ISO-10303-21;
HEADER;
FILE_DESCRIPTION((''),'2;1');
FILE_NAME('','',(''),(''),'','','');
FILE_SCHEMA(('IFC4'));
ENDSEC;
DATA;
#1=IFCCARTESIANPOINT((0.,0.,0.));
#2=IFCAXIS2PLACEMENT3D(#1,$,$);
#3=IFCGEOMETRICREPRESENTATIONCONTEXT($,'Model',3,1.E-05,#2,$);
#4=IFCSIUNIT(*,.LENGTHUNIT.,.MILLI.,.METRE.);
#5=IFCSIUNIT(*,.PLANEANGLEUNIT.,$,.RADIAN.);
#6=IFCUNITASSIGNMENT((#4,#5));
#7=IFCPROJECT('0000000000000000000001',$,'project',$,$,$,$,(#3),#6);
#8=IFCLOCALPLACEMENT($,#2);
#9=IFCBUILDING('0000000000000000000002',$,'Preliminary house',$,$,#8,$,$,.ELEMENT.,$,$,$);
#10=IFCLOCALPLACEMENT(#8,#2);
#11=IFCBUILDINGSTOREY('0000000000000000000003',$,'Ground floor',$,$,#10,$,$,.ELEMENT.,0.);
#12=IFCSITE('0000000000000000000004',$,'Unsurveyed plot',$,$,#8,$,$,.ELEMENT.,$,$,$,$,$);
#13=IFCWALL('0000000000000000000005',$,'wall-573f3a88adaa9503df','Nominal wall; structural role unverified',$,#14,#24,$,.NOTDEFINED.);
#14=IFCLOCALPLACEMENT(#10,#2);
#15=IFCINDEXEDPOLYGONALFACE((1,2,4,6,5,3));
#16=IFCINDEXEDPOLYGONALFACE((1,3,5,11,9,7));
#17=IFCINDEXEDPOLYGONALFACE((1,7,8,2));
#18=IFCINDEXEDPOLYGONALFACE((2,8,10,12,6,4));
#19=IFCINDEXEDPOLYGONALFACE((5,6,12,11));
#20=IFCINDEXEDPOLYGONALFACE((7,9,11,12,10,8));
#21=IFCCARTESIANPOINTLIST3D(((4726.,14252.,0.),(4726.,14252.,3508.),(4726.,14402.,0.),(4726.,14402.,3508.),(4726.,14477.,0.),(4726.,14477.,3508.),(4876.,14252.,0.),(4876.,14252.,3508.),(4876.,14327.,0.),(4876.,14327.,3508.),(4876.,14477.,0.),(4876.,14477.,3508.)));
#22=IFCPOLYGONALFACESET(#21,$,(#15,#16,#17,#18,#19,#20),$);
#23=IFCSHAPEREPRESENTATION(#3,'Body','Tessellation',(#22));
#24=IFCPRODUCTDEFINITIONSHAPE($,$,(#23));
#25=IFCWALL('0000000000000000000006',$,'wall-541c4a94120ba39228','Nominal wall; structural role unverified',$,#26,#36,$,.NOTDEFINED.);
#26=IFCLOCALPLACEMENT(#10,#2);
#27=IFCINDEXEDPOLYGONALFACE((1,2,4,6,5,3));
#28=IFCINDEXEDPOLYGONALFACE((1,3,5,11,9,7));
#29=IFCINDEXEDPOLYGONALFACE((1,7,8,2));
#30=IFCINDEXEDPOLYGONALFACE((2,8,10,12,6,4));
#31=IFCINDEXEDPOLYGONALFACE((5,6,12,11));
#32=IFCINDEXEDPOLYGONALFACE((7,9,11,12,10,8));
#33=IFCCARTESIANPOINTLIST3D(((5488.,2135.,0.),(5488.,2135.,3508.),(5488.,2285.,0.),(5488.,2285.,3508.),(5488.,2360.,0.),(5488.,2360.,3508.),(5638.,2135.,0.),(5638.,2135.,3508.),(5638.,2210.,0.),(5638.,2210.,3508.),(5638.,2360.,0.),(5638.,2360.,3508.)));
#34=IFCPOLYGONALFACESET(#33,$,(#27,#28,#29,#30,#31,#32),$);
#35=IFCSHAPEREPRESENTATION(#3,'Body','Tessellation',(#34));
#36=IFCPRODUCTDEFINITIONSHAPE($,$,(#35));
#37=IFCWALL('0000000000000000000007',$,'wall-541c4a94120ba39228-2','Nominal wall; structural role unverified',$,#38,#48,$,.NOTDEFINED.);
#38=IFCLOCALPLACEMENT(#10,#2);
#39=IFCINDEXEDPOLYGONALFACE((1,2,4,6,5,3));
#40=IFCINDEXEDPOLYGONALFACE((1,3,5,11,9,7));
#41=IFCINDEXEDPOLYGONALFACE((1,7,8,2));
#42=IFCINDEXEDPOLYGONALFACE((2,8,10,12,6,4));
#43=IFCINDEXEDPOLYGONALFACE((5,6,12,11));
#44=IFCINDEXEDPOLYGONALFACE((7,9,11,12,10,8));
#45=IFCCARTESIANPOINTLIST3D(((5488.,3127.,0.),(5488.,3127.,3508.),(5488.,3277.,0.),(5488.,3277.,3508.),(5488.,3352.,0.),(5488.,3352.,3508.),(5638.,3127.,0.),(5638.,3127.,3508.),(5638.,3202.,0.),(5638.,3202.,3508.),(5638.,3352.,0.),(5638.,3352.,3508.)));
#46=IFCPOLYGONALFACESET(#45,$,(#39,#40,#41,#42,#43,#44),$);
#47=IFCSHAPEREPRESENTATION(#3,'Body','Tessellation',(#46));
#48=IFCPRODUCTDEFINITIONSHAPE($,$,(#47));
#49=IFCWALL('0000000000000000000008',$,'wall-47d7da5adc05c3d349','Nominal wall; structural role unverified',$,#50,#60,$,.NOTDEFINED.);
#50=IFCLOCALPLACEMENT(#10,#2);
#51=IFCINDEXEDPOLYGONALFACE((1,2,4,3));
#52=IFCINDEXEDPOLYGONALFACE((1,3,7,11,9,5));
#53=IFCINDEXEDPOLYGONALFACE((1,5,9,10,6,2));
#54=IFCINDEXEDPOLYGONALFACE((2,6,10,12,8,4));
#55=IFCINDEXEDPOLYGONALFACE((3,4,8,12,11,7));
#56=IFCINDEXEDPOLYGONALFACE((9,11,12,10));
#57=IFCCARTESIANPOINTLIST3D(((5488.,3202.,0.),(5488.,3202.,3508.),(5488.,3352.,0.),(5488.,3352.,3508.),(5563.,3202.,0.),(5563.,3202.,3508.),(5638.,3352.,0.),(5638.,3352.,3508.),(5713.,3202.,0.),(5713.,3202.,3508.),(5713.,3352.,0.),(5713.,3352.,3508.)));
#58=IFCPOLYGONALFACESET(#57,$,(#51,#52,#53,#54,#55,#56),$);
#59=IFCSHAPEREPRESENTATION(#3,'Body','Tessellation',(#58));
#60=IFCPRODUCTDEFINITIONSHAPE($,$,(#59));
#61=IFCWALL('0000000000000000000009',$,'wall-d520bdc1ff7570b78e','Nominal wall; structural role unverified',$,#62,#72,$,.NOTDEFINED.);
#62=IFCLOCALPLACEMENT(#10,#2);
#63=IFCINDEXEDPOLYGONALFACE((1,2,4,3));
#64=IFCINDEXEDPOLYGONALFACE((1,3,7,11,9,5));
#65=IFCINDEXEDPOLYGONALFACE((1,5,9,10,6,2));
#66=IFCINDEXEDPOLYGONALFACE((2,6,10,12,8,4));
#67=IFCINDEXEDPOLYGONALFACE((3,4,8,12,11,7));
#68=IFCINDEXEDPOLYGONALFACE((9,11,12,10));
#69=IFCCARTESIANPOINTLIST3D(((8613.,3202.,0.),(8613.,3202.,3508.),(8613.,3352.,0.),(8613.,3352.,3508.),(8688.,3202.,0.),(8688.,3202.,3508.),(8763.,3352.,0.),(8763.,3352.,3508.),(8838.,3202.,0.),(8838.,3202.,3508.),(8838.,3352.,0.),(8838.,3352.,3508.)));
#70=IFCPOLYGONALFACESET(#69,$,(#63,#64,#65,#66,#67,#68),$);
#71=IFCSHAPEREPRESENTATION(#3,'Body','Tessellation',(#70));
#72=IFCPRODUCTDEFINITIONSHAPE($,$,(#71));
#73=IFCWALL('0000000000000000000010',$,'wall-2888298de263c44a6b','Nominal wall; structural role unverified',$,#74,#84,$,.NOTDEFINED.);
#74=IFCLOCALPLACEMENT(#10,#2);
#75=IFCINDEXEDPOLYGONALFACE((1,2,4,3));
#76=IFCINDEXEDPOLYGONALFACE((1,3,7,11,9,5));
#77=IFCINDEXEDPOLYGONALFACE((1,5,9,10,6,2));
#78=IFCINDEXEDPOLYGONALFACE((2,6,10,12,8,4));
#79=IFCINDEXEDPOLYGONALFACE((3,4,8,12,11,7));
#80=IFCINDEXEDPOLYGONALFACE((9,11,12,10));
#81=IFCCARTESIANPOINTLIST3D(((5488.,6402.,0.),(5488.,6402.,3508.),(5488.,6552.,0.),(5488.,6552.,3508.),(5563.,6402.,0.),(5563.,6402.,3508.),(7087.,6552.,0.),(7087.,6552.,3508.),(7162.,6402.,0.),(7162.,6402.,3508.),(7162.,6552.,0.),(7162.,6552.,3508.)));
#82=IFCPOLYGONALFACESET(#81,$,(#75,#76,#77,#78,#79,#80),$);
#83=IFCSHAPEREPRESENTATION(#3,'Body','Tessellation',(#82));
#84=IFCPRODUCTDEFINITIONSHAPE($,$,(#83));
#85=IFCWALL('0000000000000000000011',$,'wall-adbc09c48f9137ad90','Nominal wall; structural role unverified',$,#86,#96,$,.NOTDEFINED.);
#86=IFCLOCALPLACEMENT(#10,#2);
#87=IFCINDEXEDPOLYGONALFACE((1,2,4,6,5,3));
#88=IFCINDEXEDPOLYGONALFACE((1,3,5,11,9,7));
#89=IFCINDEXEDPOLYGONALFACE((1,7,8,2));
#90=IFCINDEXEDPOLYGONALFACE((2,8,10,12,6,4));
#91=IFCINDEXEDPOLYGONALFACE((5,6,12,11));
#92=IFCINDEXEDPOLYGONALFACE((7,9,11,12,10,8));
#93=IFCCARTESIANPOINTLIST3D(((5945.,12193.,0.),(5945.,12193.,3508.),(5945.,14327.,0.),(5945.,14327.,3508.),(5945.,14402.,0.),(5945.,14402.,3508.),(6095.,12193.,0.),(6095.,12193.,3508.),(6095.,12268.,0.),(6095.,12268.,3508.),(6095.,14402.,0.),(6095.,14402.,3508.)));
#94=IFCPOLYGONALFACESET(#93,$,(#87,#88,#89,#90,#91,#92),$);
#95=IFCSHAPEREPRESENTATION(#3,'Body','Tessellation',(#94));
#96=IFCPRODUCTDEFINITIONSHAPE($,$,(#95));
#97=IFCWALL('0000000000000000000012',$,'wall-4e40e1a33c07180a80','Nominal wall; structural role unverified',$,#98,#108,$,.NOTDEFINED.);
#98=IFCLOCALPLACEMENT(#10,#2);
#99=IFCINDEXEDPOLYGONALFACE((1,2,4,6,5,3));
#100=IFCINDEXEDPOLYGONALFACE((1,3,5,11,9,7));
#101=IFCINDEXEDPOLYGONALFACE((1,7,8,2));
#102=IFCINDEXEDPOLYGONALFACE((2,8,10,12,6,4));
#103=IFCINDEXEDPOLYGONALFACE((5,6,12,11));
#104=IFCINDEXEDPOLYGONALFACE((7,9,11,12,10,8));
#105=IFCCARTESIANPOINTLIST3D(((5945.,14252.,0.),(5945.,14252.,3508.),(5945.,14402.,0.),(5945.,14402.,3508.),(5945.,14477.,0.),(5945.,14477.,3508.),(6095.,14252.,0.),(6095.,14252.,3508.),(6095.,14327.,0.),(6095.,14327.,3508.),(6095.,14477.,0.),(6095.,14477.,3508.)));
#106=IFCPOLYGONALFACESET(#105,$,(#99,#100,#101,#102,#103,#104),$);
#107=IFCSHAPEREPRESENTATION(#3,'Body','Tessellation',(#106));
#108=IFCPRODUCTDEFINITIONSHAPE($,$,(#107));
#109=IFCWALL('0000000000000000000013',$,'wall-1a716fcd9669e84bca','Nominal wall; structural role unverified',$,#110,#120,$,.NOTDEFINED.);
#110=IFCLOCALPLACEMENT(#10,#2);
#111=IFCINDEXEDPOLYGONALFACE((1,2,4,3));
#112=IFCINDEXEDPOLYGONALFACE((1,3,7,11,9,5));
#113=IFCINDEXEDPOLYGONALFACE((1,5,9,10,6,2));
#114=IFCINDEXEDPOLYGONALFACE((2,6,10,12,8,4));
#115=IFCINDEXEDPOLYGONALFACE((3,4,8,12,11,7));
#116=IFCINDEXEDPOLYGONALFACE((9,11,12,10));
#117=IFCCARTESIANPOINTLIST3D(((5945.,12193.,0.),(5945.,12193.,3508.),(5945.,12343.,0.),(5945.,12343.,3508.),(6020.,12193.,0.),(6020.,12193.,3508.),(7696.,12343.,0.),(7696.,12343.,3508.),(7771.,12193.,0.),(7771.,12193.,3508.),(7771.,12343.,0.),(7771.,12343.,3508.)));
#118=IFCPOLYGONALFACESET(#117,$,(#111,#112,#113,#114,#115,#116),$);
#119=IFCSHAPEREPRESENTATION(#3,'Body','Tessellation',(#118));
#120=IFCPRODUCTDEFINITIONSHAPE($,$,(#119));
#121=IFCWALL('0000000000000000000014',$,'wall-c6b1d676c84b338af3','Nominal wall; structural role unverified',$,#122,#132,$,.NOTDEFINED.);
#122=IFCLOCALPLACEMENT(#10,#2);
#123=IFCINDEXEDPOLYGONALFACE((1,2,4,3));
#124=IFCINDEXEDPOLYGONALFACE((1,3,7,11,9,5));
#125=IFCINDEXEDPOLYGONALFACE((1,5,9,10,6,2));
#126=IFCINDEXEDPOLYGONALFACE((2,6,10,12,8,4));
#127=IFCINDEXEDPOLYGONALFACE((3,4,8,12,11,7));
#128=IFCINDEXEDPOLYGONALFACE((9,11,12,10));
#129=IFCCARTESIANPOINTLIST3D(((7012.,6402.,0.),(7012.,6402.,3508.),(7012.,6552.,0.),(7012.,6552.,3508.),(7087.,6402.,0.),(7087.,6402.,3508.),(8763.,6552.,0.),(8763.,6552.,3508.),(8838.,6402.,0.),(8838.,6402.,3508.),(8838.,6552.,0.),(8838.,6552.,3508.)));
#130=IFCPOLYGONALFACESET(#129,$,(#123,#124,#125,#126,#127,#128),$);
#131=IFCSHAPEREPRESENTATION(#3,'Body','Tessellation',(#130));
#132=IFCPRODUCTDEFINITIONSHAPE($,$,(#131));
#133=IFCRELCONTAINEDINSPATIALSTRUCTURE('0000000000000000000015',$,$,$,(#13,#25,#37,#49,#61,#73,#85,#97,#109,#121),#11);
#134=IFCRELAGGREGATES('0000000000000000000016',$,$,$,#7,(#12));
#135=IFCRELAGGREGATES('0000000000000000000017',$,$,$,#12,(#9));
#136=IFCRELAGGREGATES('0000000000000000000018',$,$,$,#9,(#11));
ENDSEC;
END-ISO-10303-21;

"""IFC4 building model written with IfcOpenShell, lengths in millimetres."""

from ifc_helpers import new_model, si_unit, origin, place, context, project, spatial, polyline, outline, extrude, element, save


model = new_model("IFC4")

# Units and contexts
model_context = context("Model", 3, precision=1e-05, world=origin())
ifc_project = project(units=[si_unit("LENGTHUNIT", "METRE", prefix="MILLI"), si_unit("PLANEANGLEUNIT", "RADIAN")], contexts=[model_context])

# Site, building, storey
placement_1 = place(None, origin())
site = spatial("IfcSite", under=ifc_project, at=placement_1, Name="Unsurveyed plot", CompositionType="ELEMENT")
building = spatial("IfcBuilding", under=site, at=placement_1, Name="Preliminary house", CompositionType="ELEMENT")
placement_2 = place(placement_1, origin())
storey = spatial("IfcBuildingStorey", under=building, at=placement_2, Name="Ground floor", CompositionType="ELEMENT", Elevation=0.0)

# Walls
element("IfcWall", 1, at=placement_2, inside=storey, Name="wall-573f3a88adaa9503df", Description="Nominal wall; structural role unverified", PredefinedType="NOTDEFINED", context=model_context, shape_type="SweptSolid", body=[
    extrude(outline(polyline([(4726.0, 14402.0), (4726.0, 14477.0), (4876.0, 14477.0), (4876.0, 14327.0), (4876.0, 14252.0), (4726.0, 14252.0), (4726.0, 14402.0)])), origin(), (0.0, 0.0, 1.0), 3508.0),
])
element("IfcWall", 2, at=placement_2, inside=storey, Name="wall-541c4a94120ba39228", Description="Nominal wall; structural role unverified", PredefinedType="NOTDEFINED", context=model_context, shape_type="SweptSolid", body=[
    extrude(outline(polyline([(5488.0, 2285.0), (5488.0, 2360.0), (5638.0, 2360.0), (5638.0, 2210.0), (5638.0, 2135.0), (5488.0, 2135.0), (5488.0, 2285.0)])), origin(), (0.0, 0.0, 1.0), 3508.0),
])

# Wall
element("IfcWall", 3, at=placement_2, inside=storey, Name="wall-541c4a94120ba39228-2", Description="Nominal wall; structural role unverified", PredefinedType="NOTDEFINED", context=model_context, shape_type="SweptSolid", body=[
    extrude(outline(polyline([(5488.0, 3277.0), (5488.0, 3352.0), (5638.0, 3352.0), (5638.0, 3202.0), (5638.0, 3127.0), (5488.0, 3127.0), (5488.0, 3277.0)])), origin(), (0.0, 0.0, 1.0), 3508.0),
])

# Wall
element("IfcWall", 4, at=placement_2, inside=storey, Name="wall-47d7da5adc05c3d349", Description="Nominal wall; structural role unverified", PredefinedType="NOTDEFINED", context=model_context, shape_type="SweptSolid", body=[
    extrude(outline(polyline([(5638.0, 3352.0), (5713.0, 3352.0), (5713.0, 3202.0), (5563.0, 3202.0), (5488.0, 3202.0), (5488.0, 3352.0), (5638.0, 3352.0)])), origin(), (0.0, 0.0, 1.0), 3508.0),
])

# Walls
element("IfcWall", 5, at=placement_2, inside=storey, Name="wall-d520bdc1ff7570b78e", Description="Nominal wall; structural role unverified", PredefinedType="NOTDEFINED", context=model_context, shape_type="SweptSolid", body=[
    extrude(outline(polyline([(8763.0, 3352.0), (8838.0, 3352.0), (8838.0, 3202.0), (8688.0, 3202.0), (8613.0, 3202.0), (8613.0, 3352.0), (8763.0, 3352.0)])), origin(), (0.0, 0.0, 1.0), 3508.0),
])
element("IfcWall", 6, at=placement_2, inside=storey, Name="wall-2888298de263c44a6b", Description="Nominal wall; structural role unverified", PredefinedType="NOTDEFINED", context=model_context, shape_type="SweptSolid", body=[
    extrude(outline(polyline([(7087.0, 6552.0), (7162.0, 6552.0), (7162.0, 6402.0), (5563.0, 6402.0), (5488.0, 6402.0), (5488.0, 6552.0), (7087.0, 6552.0)])), origin(), (0.0, 0.0, 1.0), 3508.0),
])
element("IfcWall", 7, at=placement_2, inside=storey, Name="wall-adbc09c48f9137ad90", Description="Nominal wall; structural role unverified", PredefinedType="NOTDEFINED", context=model_context, shape_type="SweptSolid", body=[
    extrude(outline(polyline([(5945.0, 14327.0), (5945.0, 14402.0), (6095.0, 14402.0), (6095.0, 12268.0), (6095.0, 12193.0), (5945.0, 12193.0), (5945.0, 14327.0)])), origin(), (0.0, 0.0, 1.0), 3508.0),
])
element("IfcWall", 8, at=placement_2, inside=storey, Name="wall-4e40e1a33c07180a80", Description="Nominal wall; structural role unverified", PredefinedType="NOTDEFINED", context=model_context, shape_type="SweptSolid", body=[
    extrude(outline(polyline([(5945.0, 14402.0), (5945.0, 14477.0), (6095.0, 14477.0), (6095.0, 14327.0), (6095.0, 14252.0), (5945.0, 14252.0), (5945.0, 14402.0)])), origin(), (0.0, 0.0, 1.0), 3508.0),
])
element("IfcWall", 9, at=placement_2, inside=storey, Name="wall-1a716fcd9669e84bca", Description="Nominal wall; structural role unverified", PredefinedType="NOTDEFINED", context=model_context, shape_type="SweptSolid", body=[
    extrude(outline(polyline([(7696.0, 12343.0), (7771.0, 12343.0), (7771.0, 12193.0), (6020.0, 12193.0), (5945.0, 12193.0), (5945.0, 12343.0), (7696.0, 12343.0)])), origin(), (0.0, 0.0, 1.0), 3508.0),
])

# Wall
element("IfcWall", 10, at=placement_2, inside=storey, Name="wall-c6b1d676c84b338af3", Description="Nominal wall; structural role unverified", PredefinedType="NOTDEFINED", context=model_context, shape_type="SweptSolid", body=[
    extrude(outline(polyline([(8763.0, 6552.0), (8838.0, 6552.0), (8838.0, 6402.0), (7087.0, 6402.0), (7012.0, 6402.0), (7012.0, 6552.0), (8763.0, 6552.0)])), origin(), (0.0, 0.0, 1.0), 3508.0),
])

save(model, "model.ifc")
